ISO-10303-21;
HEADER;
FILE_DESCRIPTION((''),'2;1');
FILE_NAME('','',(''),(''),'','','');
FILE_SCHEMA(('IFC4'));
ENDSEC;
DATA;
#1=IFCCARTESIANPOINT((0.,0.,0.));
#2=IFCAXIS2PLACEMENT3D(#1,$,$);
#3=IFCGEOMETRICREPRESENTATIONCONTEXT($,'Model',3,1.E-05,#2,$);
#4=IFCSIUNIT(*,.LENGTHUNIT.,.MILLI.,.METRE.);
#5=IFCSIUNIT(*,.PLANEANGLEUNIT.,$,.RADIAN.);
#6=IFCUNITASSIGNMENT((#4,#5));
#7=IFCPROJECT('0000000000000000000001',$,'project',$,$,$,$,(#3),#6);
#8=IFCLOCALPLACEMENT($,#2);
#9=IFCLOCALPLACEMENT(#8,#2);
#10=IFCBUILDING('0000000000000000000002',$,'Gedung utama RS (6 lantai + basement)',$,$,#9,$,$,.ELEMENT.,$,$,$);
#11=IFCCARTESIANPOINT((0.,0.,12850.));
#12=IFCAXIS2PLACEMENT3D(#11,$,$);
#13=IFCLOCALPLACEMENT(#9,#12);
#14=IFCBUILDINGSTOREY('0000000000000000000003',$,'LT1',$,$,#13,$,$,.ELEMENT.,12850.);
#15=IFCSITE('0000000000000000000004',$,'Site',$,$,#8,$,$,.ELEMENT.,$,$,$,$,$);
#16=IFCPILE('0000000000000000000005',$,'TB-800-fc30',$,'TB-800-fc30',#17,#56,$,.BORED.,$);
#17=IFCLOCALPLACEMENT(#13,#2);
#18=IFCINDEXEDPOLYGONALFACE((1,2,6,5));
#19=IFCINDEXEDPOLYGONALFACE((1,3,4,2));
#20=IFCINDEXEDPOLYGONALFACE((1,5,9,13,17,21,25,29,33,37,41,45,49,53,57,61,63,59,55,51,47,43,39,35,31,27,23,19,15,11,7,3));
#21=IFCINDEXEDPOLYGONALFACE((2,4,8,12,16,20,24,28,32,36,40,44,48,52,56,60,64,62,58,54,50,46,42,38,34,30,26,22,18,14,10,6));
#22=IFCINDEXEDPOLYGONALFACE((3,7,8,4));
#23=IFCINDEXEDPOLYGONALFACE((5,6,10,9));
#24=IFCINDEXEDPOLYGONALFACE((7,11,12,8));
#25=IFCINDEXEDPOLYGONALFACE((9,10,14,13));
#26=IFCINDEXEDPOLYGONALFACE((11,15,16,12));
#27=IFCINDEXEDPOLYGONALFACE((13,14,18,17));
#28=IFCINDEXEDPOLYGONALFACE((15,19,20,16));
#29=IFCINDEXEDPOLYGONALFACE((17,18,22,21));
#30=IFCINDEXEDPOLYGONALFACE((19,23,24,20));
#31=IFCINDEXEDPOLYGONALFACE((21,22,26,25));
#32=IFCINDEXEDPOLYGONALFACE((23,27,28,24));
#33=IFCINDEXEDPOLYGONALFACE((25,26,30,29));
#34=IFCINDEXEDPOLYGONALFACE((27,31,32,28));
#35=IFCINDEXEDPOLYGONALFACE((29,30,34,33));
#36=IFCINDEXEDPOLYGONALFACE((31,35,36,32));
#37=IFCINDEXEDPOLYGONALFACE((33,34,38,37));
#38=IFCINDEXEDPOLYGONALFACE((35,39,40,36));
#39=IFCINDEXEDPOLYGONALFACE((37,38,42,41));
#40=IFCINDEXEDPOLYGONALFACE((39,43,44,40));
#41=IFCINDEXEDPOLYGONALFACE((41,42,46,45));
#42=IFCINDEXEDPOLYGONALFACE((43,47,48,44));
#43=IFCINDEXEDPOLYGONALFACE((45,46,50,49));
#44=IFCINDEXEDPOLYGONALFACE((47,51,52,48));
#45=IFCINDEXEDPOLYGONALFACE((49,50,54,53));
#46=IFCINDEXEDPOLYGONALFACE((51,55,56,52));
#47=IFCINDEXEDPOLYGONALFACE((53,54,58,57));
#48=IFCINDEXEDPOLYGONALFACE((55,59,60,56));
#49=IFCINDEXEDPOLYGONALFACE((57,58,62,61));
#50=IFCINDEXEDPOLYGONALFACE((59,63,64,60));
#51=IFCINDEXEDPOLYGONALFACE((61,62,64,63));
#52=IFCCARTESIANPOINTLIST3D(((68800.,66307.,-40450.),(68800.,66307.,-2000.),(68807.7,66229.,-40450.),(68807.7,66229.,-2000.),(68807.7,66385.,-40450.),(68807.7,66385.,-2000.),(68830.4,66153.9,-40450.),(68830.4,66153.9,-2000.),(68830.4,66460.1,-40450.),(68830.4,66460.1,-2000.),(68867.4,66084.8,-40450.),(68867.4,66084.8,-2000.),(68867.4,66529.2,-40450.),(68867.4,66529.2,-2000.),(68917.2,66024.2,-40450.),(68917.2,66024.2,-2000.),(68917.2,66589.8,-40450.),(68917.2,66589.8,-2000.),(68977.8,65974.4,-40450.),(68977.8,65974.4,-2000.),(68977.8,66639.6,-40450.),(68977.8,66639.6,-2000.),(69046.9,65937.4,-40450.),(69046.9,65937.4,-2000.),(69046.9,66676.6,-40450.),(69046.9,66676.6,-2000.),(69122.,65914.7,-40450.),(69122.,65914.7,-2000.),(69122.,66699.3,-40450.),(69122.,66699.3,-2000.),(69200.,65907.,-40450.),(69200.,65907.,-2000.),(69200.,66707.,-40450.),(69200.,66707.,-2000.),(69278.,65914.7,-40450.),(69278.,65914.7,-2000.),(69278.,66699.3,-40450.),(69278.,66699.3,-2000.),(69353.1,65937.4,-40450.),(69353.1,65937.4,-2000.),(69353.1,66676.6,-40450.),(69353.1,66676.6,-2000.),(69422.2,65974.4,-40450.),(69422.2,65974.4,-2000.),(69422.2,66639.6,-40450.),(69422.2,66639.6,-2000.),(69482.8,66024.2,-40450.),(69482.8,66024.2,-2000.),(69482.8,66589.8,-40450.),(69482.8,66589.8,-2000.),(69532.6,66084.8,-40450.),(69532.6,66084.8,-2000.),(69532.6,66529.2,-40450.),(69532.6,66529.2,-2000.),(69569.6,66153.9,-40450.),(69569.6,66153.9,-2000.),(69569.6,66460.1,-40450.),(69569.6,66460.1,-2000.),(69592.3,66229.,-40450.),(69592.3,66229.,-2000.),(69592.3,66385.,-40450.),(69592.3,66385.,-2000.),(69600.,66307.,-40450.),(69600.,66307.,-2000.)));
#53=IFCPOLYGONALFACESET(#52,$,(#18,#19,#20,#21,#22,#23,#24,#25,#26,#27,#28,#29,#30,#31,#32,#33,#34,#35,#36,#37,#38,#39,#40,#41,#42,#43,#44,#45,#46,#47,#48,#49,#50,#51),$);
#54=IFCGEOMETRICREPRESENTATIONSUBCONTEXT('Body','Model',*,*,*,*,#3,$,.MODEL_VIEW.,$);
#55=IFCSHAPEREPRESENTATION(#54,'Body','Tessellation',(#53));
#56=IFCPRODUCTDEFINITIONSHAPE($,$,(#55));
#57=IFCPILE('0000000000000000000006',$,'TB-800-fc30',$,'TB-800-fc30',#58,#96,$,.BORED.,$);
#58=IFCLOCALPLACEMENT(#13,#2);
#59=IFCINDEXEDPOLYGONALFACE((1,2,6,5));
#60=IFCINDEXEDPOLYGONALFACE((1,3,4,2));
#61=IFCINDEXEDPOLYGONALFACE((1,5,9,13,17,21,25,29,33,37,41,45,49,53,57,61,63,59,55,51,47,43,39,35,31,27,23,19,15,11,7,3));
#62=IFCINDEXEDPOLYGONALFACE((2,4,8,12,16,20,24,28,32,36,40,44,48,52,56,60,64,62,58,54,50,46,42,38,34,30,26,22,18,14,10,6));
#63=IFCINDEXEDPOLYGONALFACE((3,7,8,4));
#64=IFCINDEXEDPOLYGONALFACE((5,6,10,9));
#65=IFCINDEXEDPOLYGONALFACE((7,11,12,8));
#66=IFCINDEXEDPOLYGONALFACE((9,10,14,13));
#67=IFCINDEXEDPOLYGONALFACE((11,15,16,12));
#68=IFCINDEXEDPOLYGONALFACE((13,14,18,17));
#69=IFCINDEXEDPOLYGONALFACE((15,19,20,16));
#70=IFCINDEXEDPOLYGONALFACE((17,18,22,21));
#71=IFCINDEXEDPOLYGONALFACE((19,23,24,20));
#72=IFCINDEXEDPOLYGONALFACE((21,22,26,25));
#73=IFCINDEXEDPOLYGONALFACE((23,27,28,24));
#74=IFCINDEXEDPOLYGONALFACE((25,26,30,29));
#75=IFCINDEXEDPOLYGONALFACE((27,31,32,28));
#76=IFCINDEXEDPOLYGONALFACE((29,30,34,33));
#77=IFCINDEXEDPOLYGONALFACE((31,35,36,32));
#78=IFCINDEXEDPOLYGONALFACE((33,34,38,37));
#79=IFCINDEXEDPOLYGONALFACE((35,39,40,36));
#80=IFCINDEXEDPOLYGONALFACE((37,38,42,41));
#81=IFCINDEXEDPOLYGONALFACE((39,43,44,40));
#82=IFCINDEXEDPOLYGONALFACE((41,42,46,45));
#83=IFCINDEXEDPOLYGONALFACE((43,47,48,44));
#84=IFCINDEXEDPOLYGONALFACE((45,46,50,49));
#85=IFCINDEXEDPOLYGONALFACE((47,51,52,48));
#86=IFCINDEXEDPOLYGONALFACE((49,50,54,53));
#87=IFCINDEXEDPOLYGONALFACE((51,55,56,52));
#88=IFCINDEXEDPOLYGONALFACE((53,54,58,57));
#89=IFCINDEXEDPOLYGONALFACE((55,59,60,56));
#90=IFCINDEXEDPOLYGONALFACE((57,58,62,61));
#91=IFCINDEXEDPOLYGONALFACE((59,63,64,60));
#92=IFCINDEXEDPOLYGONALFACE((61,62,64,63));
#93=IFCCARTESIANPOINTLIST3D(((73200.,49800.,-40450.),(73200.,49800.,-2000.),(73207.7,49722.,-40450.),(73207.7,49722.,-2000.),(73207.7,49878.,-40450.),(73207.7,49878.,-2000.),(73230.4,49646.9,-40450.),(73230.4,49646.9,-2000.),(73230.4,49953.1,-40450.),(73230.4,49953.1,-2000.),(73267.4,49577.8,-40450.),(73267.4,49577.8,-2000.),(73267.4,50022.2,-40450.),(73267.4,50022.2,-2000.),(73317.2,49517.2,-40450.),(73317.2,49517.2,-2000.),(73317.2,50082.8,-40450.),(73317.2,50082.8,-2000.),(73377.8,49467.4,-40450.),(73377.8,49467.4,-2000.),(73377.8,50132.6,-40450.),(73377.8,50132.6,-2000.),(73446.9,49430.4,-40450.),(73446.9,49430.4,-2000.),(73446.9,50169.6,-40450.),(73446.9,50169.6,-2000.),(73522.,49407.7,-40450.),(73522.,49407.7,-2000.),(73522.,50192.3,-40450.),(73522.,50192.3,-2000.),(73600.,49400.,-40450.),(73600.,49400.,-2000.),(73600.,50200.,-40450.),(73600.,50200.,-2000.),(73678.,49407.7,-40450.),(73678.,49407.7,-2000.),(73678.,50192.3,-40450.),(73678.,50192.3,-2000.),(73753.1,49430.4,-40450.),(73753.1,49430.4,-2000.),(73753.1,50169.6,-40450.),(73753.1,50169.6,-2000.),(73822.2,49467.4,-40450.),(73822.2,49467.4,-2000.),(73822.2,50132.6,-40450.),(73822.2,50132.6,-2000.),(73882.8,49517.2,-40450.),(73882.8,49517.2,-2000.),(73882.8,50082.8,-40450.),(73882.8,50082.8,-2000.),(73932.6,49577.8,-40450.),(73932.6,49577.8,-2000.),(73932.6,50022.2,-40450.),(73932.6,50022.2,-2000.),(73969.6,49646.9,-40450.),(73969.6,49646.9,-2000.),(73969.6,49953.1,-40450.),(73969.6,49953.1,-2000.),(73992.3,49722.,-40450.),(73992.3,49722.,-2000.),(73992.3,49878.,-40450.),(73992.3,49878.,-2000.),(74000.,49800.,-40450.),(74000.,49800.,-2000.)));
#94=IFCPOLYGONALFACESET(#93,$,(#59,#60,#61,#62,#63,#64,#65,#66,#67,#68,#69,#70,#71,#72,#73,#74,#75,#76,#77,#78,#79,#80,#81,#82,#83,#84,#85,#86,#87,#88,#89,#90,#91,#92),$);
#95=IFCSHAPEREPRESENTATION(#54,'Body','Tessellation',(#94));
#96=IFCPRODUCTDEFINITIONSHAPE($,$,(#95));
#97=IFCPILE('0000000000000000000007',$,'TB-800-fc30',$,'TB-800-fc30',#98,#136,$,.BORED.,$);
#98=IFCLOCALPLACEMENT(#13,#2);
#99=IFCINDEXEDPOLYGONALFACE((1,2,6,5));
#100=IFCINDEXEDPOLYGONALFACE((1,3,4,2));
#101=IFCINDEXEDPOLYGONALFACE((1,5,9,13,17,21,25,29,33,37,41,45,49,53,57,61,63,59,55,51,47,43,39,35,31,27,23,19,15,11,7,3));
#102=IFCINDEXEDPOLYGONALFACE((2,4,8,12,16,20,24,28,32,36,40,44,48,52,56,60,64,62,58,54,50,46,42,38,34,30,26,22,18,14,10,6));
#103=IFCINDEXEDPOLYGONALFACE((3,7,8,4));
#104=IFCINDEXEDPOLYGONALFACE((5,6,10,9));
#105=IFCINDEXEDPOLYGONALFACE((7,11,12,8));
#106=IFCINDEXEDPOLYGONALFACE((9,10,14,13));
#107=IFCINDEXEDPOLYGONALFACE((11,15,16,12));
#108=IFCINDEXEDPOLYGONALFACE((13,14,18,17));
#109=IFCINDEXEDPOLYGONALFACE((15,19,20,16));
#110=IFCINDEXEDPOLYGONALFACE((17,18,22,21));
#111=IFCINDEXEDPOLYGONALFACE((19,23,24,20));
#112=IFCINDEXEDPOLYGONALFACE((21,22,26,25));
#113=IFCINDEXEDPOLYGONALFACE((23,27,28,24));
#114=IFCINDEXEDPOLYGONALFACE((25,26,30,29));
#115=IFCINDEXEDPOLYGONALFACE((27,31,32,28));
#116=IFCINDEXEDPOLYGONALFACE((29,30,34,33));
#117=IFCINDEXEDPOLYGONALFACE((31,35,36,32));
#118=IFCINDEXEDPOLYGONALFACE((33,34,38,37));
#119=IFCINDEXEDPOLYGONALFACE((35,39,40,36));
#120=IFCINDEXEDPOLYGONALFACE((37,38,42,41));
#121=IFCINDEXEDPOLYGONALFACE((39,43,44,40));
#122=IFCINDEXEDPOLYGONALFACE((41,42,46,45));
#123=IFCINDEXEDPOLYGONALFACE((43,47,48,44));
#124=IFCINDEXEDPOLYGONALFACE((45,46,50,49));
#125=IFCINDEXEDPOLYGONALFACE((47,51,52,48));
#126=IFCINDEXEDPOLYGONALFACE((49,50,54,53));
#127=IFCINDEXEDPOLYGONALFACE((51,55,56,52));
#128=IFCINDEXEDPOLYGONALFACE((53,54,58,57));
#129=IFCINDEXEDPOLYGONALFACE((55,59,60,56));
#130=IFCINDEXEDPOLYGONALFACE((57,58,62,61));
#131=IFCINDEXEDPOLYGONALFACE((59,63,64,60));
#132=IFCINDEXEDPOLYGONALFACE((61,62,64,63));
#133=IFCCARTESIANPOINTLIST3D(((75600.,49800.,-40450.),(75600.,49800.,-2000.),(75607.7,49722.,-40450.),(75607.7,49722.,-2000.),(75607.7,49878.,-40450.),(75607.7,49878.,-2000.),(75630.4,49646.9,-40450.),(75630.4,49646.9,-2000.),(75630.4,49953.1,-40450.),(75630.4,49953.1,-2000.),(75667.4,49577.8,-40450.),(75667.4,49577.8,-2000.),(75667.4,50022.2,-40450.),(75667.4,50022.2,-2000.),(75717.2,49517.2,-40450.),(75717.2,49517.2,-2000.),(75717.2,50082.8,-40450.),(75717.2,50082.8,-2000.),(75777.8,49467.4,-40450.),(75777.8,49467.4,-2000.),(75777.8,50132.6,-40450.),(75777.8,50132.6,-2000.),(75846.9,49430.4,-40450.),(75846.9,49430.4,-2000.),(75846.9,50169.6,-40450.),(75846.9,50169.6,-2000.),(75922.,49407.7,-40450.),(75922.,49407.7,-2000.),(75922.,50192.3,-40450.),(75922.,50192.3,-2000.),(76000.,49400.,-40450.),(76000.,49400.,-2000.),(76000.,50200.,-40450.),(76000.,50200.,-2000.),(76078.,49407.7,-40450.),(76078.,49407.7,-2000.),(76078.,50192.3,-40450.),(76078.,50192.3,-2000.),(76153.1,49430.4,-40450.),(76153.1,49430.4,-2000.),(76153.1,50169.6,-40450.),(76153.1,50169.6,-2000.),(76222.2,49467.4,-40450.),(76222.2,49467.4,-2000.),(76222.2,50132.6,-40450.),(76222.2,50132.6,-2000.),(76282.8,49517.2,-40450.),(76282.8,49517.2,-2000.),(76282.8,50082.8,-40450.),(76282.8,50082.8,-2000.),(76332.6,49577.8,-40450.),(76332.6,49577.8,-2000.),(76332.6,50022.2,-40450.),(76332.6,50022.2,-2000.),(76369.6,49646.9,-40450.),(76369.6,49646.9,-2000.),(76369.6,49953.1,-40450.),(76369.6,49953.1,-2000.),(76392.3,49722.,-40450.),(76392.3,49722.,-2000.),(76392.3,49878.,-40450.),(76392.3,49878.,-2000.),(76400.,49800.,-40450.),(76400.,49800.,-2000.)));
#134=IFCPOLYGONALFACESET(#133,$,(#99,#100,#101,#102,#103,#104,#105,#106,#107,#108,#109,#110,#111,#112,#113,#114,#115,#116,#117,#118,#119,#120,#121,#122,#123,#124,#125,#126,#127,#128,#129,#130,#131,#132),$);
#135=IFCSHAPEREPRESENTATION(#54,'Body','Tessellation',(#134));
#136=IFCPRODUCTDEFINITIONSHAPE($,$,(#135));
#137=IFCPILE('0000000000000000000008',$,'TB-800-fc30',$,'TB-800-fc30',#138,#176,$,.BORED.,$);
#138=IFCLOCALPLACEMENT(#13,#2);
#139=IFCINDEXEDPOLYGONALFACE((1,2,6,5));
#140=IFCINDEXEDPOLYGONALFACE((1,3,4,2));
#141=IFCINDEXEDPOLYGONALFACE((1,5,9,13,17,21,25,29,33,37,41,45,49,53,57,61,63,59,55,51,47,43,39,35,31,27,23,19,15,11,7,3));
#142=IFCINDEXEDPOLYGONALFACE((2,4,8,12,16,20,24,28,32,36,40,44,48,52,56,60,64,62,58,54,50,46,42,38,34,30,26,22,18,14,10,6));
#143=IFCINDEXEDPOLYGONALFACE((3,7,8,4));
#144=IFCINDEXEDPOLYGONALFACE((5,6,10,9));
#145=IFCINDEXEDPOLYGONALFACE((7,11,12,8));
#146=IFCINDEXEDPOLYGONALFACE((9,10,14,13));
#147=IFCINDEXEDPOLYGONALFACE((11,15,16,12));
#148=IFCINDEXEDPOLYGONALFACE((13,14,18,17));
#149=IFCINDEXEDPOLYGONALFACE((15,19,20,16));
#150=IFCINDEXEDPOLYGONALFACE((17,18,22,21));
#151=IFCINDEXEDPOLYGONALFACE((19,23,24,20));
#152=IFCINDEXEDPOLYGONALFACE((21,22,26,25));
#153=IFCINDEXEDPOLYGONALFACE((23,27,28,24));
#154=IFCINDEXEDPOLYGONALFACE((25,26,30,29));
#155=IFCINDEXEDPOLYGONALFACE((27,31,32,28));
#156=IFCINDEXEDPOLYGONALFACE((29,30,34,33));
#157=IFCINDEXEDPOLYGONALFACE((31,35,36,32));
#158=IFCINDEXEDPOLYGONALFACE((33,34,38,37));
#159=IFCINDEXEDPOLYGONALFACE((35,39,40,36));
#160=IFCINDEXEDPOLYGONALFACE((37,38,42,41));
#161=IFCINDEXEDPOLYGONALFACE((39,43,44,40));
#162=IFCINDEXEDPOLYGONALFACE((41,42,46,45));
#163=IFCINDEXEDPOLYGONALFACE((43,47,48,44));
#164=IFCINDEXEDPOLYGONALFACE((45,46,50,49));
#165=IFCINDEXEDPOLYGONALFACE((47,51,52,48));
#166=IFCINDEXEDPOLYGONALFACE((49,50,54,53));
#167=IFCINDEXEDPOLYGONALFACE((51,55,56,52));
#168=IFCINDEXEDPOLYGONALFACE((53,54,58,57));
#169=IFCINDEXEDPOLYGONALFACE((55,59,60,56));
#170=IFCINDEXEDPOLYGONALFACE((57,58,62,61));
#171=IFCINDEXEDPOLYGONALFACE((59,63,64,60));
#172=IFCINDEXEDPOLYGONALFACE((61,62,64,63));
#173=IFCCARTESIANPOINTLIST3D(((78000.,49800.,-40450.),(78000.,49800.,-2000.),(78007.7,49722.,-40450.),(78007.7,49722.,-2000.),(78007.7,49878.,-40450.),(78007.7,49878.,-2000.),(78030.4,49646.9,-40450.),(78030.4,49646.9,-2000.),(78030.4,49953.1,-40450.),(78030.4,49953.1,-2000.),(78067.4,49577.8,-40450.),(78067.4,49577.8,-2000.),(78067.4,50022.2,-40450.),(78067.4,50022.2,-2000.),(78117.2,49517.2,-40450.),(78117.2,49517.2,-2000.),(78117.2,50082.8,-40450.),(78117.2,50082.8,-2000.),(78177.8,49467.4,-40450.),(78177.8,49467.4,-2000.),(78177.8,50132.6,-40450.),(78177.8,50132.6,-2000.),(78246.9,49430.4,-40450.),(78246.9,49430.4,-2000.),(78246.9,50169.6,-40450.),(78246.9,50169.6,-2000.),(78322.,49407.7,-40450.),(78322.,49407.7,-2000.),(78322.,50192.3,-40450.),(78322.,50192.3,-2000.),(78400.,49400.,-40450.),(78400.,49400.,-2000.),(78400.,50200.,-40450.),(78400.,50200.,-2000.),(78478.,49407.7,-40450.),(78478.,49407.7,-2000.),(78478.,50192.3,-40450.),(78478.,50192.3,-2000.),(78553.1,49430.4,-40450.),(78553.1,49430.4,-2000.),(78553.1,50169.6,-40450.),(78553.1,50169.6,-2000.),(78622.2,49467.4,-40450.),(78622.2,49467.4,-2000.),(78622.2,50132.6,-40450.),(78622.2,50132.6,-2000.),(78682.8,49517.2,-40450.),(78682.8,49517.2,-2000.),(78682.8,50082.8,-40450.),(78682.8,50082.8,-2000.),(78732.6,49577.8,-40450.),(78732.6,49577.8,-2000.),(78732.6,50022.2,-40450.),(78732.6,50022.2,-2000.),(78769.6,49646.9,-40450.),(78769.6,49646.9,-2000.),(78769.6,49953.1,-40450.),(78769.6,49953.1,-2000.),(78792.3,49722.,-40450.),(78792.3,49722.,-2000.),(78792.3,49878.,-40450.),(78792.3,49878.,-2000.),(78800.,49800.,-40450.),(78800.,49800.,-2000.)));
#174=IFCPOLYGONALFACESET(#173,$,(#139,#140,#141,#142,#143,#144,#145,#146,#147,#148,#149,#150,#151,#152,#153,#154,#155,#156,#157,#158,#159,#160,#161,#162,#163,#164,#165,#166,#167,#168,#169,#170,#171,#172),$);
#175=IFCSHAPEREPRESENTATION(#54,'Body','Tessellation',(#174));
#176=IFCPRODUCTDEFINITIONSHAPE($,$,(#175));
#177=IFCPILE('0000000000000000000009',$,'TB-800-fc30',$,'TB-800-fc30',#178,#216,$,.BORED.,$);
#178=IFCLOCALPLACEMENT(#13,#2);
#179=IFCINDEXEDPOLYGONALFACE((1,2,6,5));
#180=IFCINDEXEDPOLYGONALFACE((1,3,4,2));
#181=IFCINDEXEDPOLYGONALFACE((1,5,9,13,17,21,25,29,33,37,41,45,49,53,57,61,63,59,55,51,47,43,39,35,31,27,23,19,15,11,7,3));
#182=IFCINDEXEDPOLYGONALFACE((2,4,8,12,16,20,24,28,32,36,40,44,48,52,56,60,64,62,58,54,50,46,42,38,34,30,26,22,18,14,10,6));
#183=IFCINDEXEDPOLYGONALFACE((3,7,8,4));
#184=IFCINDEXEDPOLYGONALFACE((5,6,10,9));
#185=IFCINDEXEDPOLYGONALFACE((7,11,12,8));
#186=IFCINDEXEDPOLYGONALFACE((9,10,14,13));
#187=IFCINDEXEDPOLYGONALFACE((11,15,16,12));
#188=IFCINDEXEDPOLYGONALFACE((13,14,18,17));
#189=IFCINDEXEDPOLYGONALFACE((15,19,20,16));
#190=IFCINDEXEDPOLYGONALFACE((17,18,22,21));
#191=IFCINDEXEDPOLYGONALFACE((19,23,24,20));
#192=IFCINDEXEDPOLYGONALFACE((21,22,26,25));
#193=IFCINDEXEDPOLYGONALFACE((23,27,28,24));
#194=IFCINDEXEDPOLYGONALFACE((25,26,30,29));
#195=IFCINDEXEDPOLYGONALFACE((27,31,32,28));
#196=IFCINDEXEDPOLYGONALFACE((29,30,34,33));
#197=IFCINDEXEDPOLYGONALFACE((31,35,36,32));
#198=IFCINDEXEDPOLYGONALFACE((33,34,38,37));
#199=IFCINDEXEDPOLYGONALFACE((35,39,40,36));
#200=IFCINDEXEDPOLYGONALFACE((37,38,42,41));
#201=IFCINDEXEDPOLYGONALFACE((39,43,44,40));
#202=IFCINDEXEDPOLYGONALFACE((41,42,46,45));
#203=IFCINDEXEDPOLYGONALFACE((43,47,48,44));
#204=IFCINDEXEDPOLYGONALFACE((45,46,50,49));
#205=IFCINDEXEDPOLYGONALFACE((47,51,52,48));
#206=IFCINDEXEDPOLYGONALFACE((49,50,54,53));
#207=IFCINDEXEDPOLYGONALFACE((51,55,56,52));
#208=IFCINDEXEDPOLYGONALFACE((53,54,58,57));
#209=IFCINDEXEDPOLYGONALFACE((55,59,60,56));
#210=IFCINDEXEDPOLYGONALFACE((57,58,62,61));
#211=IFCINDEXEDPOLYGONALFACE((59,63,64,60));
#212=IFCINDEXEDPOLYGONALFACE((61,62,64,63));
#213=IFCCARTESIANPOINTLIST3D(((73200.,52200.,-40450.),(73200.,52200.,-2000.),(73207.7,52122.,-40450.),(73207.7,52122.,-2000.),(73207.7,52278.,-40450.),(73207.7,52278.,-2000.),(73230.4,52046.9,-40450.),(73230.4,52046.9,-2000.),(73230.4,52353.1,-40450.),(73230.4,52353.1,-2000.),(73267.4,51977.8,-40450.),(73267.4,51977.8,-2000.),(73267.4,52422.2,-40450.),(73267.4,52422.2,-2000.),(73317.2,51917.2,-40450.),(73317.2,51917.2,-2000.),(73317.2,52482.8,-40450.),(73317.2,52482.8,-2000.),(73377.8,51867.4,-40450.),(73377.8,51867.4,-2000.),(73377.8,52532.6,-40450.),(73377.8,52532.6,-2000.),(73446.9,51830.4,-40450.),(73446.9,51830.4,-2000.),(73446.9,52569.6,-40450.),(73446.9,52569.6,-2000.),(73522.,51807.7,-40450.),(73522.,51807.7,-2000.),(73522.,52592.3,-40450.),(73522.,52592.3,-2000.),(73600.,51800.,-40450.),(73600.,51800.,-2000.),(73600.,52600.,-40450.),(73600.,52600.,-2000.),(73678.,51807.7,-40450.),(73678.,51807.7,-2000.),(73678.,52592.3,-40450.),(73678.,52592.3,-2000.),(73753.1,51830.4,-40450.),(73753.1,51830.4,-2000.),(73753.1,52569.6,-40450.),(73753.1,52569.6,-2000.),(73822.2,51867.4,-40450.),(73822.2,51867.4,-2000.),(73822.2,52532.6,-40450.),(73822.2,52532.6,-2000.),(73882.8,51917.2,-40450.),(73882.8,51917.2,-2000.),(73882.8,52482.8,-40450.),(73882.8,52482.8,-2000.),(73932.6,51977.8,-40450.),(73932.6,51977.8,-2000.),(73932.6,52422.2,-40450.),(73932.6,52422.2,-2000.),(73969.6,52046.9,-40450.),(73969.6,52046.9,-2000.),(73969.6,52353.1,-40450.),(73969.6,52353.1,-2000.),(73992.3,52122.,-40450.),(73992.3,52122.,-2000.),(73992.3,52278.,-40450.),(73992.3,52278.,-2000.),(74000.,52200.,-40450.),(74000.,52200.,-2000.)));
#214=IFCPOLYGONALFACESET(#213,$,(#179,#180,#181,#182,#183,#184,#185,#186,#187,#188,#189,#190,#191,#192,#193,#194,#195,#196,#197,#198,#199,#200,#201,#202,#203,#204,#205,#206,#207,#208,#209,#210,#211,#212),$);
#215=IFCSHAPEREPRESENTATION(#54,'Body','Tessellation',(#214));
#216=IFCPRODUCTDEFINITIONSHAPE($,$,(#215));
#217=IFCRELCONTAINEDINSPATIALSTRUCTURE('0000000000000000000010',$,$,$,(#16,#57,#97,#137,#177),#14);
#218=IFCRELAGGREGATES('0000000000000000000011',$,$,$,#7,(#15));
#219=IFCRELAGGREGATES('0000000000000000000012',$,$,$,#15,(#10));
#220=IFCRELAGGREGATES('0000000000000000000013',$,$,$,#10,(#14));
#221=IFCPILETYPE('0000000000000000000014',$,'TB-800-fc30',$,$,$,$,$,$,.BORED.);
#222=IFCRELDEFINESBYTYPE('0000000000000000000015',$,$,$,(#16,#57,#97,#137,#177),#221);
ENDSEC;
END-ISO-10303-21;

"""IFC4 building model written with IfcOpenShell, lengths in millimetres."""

from ifc_helpers import new_model, si_unit, frame, origin, origin_2d, place, context, subcontext, project, spatial, circle, extrude, material_profile, profile_set, profile_usage, type_object, element, save


model = new_model("IFC4")

# Units and contexts
model_context = context("Model", 3, precision=1e-05, world=origin())
body_context = subcontext(model_context, "Body", "Model", "MODEL_VIEW")
ifc_project = project(units=[si_unit("LENGTHUNIT", "METRE", prefix="MILLI"), si_unit("PLANEANGLEUNIT", "RADIAN")], contexts=[model_context])

# Site, building, storey
site_placement = place(None, origin())
site = spatial("IfcSite", under=ifc_project, at=site_placement, Name="Site", CompositionType="ELEMENT")
building_placement = place(site_placement, origin())
building = spatial("IfcBuilding", under=site, at=building_placement, Name="Gedung utama RS (6 lantai + basement)", CompositionType="ELEMENT")
storey_placement = place(building_placement, frame((0.0, 0.0, 12850.0)))
storey = spatial("IfcBuildingStorey", under=building, at=storey_placement, Name="LT1", CompositionType="ELEMENT", Elevation=12850.0)

# Piles
ifc_material_profile = material_profile(None, circle(Radius=400.0, at=origin_2d()), Name="TB-800-fc30")
ifc_profile_set = profile_set([ifc_material_profile], Name="TB-800-fc30")
ifc_profile_usage = profile_usage(ifc_profile_set, cardinal=5)
pile_type = type_object("IfcPileType", Name="TB-800-fc30", PredefinedType="BORED", material=ifc_profile_set)
for number, where, z_axis, x_axis, name in (
    (1, (69200.0, 66307.0, -40450.0), (0.0, 0.0, 1.0), (1.0, 0.0, 0.0), "TB-800-fc30"),
    (2, (73600.0, 49800.0, -40450.0), (0.0, 0.0, 1.0), (1.0, 0.0, 0.0), "TB-800-fc30"),
    (3, (76000.0, 49800.0, -40450.0), (0.0, 0.0, 1.0), (1.0, 0.0, 0.0), "TB-800-fc30"),
    (4, (78400.0, 49800.0, -40450.0), (0.0, 0.0, 1.0), (1.0, 0.0, 0.0), "TB-800-fc30"),
    (5, (73600.0, 52200.0, -40450.0), (0.0, 0.0, 1.0), (1.0, 0.0, 0.0), "TB-800-fc30"),
):
    element("IfcPile", number, at=place(storey_placement, frame(where, z_axis=z_axis, x_axis=x_axis)), inside=storey, type_object=pile_type, material=ifc_profile_usage, Name=name, ObjectType="TB-800-fc30", PredefinedType="BORED", context=body_context, shape_type="SweptSolid", body=[
        extrude(circle(Radius=400.0, at=origin_2d()), origin(), (0.0, 0.0, 1.0), 38450.0),
    ])

save(model, "model.ifc")
